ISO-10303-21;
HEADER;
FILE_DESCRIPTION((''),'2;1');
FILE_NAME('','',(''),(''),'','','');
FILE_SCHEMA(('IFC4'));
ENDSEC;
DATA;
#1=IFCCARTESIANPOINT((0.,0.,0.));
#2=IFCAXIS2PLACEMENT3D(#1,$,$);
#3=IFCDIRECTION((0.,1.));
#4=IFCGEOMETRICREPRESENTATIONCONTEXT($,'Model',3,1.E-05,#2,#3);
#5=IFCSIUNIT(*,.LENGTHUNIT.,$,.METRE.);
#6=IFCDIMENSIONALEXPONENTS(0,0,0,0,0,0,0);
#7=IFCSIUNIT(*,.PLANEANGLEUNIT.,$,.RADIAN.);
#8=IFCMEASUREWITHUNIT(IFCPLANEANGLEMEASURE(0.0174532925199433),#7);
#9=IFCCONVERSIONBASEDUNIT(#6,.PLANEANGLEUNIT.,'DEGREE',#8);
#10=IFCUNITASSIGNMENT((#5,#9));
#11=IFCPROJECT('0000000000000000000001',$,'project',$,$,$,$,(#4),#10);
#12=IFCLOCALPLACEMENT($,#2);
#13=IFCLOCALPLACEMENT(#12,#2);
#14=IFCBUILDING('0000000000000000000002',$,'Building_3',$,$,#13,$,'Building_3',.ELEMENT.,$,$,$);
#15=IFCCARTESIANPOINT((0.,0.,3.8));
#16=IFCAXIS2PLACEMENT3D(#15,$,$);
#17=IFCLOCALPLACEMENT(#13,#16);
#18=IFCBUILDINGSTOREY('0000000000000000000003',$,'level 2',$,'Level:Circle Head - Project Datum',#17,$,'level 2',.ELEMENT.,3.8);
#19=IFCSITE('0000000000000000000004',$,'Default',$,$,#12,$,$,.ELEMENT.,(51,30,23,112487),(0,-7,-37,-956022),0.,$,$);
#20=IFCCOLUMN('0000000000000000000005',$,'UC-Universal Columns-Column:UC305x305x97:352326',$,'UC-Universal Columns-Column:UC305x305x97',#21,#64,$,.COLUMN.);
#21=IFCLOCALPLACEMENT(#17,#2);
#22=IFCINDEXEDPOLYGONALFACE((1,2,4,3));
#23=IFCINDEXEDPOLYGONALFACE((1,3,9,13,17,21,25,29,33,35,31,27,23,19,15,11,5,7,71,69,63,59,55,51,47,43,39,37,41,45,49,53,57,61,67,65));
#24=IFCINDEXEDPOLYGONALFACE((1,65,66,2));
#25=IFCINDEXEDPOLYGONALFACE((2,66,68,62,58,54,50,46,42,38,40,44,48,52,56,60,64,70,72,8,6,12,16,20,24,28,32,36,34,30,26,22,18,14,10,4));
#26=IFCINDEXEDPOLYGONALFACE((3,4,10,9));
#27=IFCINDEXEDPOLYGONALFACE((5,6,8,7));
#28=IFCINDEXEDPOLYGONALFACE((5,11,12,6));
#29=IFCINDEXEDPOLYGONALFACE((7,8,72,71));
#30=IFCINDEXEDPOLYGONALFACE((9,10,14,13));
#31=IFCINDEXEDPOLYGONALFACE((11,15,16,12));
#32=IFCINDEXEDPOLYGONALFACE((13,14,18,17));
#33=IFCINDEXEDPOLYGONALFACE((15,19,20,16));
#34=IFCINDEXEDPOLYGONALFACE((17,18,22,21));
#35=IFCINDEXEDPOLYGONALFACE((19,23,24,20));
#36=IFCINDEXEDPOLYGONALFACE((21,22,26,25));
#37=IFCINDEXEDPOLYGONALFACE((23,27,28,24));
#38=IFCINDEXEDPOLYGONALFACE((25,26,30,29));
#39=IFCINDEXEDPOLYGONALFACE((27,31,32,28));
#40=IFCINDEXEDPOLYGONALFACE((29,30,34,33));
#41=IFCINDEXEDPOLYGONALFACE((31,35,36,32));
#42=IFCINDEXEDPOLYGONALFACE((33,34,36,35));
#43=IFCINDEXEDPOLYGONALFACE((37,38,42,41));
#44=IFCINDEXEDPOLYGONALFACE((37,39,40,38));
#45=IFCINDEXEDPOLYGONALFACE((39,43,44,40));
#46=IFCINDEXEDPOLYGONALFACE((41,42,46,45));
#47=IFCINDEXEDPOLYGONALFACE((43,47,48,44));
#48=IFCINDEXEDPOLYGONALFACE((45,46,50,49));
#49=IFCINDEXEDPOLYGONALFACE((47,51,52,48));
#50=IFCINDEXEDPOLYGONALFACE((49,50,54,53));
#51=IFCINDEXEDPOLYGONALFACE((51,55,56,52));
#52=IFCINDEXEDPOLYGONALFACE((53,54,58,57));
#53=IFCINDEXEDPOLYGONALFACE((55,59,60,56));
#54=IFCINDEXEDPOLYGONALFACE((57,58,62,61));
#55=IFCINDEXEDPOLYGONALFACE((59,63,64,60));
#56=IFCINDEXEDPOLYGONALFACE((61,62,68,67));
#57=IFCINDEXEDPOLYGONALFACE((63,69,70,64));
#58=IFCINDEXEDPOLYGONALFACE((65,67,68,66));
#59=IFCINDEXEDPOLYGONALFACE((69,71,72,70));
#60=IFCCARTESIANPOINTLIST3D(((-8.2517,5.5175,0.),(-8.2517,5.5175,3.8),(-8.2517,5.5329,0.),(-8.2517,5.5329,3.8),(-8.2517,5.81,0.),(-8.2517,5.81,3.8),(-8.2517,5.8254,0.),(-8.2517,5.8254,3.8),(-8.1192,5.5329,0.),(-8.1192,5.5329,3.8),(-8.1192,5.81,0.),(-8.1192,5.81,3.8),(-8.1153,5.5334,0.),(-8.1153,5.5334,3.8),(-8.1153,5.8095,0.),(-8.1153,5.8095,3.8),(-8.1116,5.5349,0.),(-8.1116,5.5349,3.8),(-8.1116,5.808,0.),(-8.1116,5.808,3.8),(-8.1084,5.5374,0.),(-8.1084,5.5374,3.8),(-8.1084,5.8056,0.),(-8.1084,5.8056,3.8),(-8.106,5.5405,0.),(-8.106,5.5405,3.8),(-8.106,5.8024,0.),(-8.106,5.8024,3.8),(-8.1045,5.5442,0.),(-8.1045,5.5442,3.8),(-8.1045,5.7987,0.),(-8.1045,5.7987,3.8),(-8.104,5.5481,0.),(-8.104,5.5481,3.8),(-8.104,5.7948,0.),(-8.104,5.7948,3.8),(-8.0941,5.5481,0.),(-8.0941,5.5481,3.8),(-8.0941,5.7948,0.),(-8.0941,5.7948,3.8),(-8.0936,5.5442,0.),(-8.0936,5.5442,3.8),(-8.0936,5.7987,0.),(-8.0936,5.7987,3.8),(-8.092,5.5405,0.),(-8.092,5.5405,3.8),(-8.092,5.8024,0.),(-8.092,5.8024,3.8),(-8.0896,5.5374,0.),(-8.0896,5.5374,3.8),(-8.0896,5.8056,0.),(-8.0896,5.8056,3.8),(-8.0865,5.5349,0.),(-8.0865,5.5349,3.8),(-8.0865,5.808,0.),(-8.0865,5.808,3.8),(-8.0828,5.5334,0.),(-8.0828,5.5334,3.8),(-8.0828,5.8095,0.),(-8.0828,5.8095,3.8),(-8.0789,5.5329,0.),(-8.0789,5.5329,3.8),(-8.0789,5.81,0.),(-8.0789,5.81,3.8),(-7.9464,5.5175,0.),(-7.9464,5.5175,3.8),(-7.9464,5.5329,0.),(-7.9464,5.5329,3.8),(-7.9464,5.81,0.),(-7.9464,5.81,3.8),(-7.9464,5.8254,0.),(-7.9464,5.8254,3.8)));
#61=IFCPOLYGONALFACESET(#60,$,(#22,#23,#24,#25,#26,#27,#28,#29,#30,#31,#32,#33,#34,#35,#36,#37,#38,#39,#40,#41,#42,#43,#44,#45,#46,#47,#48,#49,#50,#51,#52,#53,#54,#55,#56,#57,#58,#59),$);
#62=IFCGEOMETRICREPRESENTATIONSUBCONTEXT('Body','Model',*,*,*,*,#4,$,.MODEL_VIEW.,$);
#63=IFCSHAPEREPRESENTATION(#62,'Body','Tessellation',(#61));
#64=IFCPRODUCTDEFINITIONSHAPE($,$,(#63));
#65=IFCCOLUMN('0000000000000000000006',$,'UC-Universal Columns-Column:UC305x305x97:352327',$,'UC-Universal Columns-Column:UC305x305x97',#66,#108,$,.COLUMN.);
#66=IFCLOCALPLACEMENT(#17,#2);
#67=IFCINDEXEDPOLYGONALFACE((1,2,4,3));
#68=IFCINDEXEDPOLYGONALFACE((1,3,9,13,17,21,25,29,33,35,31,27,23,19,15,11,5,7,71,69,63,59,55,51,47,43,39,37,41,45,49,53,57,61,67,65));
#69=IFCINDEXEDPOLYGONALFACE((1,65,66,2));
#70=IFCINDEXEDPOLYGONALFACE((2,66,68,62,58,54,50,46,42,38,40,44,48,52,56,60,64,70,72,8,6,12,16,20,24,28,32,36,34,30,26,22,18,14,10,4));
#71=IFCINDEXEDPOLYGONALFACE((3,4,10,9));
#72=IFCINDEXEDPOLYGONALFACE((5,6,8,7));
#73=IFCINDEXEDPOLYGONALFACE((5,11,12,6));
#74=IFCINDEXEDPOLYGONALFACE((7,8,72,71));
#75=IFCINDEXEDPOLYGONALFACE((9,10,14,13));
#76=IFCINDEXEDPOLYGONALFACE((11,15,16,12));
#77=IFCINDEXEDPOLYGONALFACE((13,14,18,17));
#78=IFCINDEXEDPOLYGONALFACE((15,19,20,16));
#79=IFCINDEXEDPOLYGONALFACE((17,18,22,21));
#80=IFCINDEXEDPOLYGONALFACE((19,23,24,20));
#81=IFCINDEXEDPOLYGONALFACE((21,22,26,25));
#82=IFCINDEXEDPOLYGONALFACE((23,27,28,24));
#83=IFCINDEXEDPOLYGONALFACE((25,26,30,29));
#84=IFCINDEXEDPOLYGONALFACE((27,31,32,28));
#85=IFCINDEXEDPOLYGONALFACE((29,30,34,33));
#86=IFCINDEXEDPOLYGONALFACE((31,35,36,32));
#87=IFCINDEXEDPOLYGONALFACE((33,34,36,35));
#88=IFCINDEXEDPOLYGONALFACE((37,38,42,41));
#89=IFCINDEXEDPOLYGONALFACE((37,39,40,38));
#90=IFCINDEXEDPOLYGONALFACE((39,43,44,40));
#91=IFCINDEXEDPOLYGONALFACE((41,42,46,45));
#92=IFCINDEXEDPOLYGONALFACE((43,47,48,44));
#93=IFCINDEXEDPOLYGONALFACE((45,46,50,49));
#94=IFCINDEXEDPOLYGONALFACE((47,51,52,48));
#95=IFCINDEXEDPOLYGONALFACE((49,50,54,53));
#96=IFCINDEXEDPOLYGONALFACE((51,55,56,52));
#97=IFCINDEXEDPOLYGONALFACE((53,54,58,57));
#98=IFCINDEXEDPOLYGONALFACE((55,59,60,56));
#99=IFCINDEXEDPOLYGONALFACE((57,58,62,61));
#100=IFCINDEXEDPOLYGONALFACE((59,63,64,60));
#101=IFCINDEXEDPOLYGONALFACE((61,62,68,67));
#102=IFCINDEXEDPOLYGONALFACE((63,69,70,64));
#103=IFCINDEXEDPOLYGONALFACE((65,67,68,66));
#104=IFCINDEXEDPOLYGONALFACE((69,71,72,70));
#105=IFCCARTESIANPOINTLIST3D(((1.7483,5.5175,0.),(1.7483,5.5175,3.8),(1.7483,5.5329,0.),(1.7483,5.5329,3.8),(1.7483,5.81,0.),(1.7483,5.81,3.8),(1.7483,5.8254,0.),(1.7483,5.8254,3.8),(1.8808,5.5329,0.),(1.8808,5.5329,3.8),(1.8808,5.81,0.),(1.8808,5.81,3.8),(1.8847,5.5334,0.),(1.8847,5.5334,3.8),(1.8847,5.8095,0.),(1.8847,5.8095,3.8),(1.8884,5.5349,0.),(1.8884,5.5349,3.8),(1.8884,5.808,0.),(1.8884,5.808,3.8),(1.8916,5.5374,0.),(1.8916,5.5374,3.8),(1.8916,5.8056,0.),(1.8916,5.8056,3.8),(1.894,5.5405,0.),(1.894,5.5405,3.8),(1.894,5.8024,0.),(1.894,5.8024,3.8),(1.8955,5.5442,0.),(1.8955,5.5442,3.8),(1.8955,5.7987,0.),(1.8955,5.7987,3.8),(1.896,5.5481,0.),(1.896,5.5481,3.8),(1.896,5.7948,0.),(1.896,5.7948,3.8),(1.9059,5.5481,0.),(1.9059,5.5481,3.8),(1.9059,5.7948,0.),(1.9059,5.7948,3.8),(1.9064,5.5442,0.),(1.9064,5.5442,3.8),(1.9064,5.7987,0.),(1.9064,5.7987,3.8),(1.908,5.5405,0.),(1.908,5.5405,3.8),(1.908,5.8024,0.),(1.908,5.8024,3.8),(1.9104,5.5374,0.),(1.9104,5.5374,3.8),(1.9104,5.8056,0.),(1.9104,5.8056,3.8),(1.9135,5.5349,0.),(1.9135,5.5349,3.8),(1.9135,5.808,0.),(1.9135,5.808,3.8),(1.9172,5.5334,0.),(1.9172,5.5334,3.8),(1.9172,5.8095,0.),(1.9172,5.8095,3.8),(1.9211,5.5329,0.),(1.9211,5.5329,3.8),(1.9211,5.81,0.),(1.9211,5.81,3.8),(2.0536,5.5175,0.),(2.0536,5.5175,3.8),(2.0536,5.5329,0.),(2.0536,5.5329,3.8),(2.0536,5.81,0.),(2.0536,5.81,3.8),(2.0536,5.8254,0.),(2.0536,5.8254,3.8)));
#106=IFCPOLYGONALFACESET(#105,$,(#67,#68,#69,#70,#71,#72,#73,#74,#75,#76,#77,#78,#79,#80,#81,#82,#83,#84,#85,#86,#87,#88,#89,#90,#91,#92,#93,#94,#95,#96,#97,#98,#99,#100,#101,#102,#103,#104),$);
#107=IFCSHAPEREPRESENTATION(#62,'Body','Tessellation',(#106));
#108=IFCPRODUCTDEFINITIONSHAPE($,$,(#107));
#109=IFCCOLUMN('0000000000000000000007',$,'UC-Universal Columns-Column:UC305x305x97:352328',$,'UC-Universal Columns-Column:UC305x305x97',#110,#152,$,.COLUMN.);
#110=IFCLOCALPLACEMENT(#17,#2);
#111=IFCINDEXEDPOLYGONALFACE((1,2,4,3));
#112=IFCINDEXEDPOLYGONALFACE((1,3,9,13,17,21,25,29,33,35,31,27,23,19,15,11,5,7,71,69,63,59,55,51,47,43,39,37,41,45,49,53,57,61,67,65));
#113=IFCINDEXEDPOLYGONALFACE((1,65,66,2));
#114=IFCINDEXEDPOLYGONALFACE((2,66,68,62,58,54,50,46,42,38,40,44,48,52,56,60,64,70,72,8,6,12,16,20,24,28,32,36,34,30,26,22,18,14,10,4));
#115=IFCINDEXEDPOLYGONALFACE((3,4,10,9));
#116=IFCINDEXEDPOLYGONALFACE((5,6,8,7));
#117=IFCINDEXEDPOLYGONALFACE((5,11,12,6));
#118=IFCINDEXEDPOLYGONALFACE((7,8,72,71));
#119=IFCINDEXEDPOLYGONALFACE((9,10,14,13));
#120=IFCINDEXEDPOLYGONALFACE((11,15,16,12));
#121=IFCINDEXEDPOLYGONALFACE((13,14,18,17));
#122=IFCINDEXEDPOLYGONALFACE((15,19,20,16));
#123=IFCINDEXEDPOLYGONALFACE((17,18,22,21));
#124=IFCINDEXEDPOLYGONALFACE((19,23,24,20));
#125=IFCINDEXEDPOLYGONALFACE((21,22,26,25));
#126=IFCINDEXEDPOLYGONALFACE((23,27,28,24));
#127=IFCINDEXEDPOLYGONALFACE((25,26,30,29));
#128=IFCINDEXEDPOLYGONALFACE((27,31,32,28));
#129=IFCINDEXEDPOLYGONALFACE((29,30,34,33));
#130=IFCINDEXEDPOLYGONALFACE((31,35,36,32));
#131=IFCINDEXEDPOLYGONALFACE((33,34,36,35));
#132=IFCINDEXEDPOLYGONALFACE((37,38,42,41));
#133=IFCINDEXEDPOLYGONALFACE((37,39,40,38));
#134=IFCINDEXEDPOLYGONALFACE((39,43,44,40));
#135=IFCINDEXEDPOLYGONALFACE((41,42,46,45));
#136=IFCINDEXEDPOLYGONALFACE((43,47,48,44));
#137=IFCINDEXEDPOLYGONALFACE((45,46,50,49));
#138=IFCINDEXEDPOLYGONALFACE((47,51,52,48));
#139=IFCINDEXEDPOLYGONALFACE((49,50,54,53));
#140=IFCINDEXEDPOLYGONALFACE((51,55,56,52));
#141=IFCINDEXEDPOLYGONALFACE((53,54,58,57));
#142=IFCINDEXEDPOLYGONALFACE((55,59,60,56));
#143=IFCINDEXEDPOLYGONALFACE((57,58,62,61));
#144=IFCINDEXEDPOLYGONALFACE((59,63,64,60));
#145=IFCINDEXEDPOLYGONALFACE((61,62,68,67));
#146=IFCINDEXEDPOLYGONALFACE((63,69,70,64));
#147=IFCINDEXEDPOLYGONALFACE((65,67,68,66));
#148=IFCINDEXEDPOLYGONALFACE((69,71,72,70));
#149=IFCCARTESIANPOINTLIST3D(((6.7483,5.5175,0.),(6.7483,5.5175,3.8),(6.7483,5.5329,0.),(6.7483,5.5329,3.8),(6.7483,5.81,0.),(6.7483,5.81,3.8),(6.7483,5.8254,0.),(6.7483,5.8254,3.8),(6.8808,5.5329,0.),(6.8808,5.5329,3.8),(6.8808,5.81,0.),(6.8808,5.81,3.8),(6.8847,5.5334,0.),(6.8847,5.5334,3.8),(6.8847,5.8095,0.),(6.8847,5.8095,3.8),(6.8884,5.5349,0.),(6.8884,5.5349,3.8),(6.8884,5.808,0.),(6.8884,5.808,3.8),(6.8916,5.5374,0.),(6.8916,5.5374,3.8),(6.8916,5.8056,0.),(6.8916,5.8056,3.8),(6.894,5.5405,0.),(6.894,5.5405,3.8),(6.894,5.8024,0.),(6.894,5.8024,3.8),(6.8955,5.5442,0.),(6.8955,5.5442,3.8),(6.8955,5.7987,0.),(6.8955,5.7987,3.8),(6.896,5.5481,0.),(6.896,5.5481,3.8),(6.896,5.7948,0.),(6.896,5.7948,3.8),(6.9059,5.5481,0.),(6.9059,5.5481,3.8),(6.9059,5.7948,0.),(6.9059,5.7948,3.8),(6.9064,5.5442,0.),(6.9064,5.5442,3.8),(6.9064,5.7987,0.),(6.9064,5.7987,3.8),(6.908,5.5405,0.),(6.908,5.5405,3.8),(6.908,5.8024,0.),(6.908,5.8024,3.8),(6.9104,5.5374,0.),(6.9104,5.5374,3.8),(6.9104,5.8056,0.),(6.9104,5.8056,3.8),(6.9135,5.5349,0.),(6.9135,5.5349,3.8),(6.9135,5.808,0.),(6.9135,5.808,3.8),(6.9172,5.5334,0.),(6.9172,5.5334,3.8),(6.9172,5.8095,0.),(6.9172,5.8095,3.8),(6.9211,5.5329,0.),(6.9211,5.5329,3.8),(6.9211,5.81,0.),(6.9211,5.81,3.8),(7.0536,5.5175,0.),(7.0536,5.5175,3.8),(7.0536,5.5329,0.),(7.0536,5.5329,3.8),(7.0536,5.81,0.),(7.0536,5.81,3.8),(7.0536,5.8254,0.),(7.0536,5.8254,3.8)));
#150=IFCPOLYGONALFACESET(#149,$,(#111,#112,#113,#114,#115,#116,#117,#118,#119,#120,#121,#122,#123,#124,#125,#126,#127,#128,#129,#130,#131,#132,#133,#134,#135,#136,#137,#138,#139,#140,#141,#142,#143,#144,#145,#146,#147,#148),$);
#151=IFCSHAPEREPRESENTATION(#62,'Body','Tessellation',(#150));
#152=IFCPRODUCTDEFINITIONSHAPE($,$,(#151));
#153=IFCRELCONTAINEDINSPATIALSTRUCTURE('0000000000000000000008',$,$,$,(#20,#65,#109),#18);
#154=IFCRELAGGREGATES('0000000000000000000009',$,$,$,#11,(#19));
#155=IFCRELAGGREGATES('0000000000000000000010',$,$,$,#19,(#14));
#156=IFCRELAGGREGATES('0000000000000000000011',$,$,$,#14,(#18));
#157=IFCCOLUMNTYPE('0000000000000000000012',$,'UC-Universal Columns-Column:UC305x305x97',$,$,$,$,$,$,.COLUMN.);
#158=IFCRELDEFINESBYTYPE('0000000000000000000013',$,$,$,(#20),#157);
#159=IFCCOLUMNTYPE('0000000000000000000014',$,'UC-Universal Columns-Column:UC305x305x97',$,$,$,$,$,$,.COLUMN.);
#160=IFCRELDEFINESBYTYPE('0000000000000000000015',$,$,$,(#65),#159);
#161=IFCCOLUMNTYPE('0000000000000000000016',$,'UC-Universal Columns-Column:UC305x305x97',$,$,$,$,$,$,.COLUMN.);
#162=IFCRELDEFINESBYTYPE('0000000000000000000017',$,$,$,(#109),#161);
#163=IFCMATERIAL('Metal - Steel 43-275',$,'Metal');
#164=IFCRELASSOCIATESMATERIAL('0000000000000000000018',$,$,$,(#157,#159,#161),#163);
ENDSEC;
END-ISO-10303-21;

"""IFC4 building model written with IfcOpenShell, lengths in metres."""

from ifc_helpers import new_model, entity, si_unit, converted_unit, direction, frame, frame_2d, origin, place, context, subcontext, project, spatial, i_section, extrude, source, transform, mapped, material, material_profile, profile_set, type_object, type_shapes, element, save


model = new_model("IFC4")

# Units and contexts
model_context = context("Model", 3, precision=1e-05, world=origin(), true_north=direction((0.0, 1.0)))
body_context = subcontext(model_context, "Body", "Model", "MODEL_VIEW")
ifc_project = project(units=[si_unit("LENGTHUNIT", "METRE"), converted_unit("PLANEANGLEUNIT", "DEGREE", entity("IfcPlaneAngleMeasure", 0.0174532925199433), si_unit("PLANEANGLEUNIT", "RADIAN"), dimensions=[0, 0, 0, 0, 0, 0, 0])], contexts=[model_context])

# Site, building, storey
site_placement = place(None, origin())
site = spatial("IfcSite", under=ifc_project, at=site_placement, Name="Default", CompositionType="ELEMENT", RefLatitude=(51, 30, 23, 112487), RefLongitude=(0, -7, -37, -956022), RefElevation=0.0)
building_placement = place(site_placement, origin())
building = spatial("IfcBuilding", under=site, at=building_placement, Name="Building_3", LongName="Building_3", CompositionType="ELEMENT")
storey_placement = place(building_placement, frame((0.0, 0.0, 3.8)))
storey = spatial("IfcBuildingStorey", under=building, at=storey_placement, Name="level 2", ObjectType="Level:Circle Head - Project Datum", LongName="level 2", CompositionType="ELEMENT", Elevation=3.8)

# Columns
ifc_material_1 = material(Name="Metal - Steel 43-275", Category="Metal")
ifc_material_profile_1 = material_profile(ifc_material_1, i_section(OverallWidth=0.3053, OverallDepth=0.3079, WebThickness=0.0099, FlangeThickness=0.0154, FilletRadius=0.0152, at=frame_2d((0.0, 0.0), x_axis=(1.0, 0.0))), Name="UC305x305x97")
ifc_profile_set_1 = profile_set([ifc_material_profile_1], Name="UC305x305x97")
column_type_1 = type_object("IfcColumnType", Name="UC-Universal Columns-Column:UC305x305x97", PredefinedType="COLUMN", material=ifc_profile_set_1)
shared_shape_1 = source(origin(), body_context, "Body", "SweptSolid", [
    extrude(i_section(OverallWidth=0.3053, OverallDepth=0.3079, WebThickness=0.0099, FlangeThickness=0.0154, FilletRadius=0.0152, at=frame_2d((0.0, 0.0), x_axis=(1.0, 0.0))), frame((-8.099, 5.6715, 3.8), z_axis=(0.0, 0.0, 1.0), x_axis=(-1.0, 0.0, 0.0)), (0.0, 0.0, 1.0), 3.8),
])
type_shapes(column_type_1, [shared_shape_1])
column_1_placement = place(storey_placement, frame((0.0, 0.0, -3.8)))
element("IfcColumn", 1, at=column_1_placement, inside=storey, type_object=column_type_1, Name="UC-Universal Columns-Column:UC305x305x97:352326", ObjectType="UC-Universal Columns-Column:UC305x305x97", PredefinedType="COLUMN", context=body_context, shape_type="MappedRepresentation", body=[
    mapped(shared_shape_1, transform((0.0, 0.0, 0.0), scale=1.0)),
])
column_type_2 = type_object("IfcColumnType", Name="UC-Universal Columns-Column:UC305x305x97", PredefinedType="COLUMN", material=ifc_profile_set_1)
shared_shape_2 = source(origin(), body_context, "Body", "SweptSolid", [
    extrude(i_section(OverallWidth=0.3053, OverallDepth=0.3079, WebThickness=0.0099, FlangeThickness=0.0154, FilletRadius=0.0152, at=frame_2d((0.0, 0.0), x_axis=(1.0, 0.0))), frame((1.901, 5.6715, 3.8), z_axis=(0.0, 0.0, 1.0), x_axis=(-1.0, 0.0, 0.0)), (0.0, 0.0, 1.0), 3.8),
])
type_shapes(column_type_2, [shared_shape_2])
column_2_placement = place(storey_placement, frame((0.0, 0.0, -3.8)))
element("IfcColumn", 2, at=column_2_placement, inside=storey, type_object=column_type_2, Name="UC-Universal Columns-Column:UC305x305x97:352327", ObjectType="UC-Universal Columns-Column:UC305x305x97", PredefinedType="COLUMN", context=body_context, shape_type="MappedRepresentation", body=[
    mapped(shared_shape_2, transform((0.0, 0.0, 0.0), scale=1.0)),
])
column_type_3 = type_object("IfcColumnType", Name="UC-Universal Columns-Column:UC305x305x97", PredefinedType="COLUMN", material=ifc_profile_set_1)
shared_shape_3 = source(origin(), body_context, "Body", "SweptSolid", [
    extrude(i_section(OverallWidth=0.3053, OverallDepth=0.3079, WebThickness=0.0099, FlangeThickness=0.0154, FilletRadius=0.0152, at=frame_2d((0.0, 0.0), x_axis=(1.0, 0.0))), frame((6.901, 5.6715, 3.8), z_axis=(0.0, 0.0, 1.0), x_axis=(-1.0, 0.0, 0.0)), (0.0, 0.0, 1.0), 3.8),
])
type_shapes(column_type_3, [shared_shape_3])
column_3_placement = place(storey_placement, frame((0.0, 0.0, -3.8)))
element("IfcColumn", 3, at=column_3_placement, inside=storey, type_object=column_type_3, Name="UC-Universal Columns-Column:UC305x305x97:352328", ObjectType="UC-Universal Columns-Column:UC305x305x97", PredefinedType="COLUMN", context=body_context, shape_type="MappedRepresentation", body=[
    mapped(shared_shape_3, transform((0.0, 0.0, 0.0), scale=1.0)),
])

save(model, "model.ifc")
